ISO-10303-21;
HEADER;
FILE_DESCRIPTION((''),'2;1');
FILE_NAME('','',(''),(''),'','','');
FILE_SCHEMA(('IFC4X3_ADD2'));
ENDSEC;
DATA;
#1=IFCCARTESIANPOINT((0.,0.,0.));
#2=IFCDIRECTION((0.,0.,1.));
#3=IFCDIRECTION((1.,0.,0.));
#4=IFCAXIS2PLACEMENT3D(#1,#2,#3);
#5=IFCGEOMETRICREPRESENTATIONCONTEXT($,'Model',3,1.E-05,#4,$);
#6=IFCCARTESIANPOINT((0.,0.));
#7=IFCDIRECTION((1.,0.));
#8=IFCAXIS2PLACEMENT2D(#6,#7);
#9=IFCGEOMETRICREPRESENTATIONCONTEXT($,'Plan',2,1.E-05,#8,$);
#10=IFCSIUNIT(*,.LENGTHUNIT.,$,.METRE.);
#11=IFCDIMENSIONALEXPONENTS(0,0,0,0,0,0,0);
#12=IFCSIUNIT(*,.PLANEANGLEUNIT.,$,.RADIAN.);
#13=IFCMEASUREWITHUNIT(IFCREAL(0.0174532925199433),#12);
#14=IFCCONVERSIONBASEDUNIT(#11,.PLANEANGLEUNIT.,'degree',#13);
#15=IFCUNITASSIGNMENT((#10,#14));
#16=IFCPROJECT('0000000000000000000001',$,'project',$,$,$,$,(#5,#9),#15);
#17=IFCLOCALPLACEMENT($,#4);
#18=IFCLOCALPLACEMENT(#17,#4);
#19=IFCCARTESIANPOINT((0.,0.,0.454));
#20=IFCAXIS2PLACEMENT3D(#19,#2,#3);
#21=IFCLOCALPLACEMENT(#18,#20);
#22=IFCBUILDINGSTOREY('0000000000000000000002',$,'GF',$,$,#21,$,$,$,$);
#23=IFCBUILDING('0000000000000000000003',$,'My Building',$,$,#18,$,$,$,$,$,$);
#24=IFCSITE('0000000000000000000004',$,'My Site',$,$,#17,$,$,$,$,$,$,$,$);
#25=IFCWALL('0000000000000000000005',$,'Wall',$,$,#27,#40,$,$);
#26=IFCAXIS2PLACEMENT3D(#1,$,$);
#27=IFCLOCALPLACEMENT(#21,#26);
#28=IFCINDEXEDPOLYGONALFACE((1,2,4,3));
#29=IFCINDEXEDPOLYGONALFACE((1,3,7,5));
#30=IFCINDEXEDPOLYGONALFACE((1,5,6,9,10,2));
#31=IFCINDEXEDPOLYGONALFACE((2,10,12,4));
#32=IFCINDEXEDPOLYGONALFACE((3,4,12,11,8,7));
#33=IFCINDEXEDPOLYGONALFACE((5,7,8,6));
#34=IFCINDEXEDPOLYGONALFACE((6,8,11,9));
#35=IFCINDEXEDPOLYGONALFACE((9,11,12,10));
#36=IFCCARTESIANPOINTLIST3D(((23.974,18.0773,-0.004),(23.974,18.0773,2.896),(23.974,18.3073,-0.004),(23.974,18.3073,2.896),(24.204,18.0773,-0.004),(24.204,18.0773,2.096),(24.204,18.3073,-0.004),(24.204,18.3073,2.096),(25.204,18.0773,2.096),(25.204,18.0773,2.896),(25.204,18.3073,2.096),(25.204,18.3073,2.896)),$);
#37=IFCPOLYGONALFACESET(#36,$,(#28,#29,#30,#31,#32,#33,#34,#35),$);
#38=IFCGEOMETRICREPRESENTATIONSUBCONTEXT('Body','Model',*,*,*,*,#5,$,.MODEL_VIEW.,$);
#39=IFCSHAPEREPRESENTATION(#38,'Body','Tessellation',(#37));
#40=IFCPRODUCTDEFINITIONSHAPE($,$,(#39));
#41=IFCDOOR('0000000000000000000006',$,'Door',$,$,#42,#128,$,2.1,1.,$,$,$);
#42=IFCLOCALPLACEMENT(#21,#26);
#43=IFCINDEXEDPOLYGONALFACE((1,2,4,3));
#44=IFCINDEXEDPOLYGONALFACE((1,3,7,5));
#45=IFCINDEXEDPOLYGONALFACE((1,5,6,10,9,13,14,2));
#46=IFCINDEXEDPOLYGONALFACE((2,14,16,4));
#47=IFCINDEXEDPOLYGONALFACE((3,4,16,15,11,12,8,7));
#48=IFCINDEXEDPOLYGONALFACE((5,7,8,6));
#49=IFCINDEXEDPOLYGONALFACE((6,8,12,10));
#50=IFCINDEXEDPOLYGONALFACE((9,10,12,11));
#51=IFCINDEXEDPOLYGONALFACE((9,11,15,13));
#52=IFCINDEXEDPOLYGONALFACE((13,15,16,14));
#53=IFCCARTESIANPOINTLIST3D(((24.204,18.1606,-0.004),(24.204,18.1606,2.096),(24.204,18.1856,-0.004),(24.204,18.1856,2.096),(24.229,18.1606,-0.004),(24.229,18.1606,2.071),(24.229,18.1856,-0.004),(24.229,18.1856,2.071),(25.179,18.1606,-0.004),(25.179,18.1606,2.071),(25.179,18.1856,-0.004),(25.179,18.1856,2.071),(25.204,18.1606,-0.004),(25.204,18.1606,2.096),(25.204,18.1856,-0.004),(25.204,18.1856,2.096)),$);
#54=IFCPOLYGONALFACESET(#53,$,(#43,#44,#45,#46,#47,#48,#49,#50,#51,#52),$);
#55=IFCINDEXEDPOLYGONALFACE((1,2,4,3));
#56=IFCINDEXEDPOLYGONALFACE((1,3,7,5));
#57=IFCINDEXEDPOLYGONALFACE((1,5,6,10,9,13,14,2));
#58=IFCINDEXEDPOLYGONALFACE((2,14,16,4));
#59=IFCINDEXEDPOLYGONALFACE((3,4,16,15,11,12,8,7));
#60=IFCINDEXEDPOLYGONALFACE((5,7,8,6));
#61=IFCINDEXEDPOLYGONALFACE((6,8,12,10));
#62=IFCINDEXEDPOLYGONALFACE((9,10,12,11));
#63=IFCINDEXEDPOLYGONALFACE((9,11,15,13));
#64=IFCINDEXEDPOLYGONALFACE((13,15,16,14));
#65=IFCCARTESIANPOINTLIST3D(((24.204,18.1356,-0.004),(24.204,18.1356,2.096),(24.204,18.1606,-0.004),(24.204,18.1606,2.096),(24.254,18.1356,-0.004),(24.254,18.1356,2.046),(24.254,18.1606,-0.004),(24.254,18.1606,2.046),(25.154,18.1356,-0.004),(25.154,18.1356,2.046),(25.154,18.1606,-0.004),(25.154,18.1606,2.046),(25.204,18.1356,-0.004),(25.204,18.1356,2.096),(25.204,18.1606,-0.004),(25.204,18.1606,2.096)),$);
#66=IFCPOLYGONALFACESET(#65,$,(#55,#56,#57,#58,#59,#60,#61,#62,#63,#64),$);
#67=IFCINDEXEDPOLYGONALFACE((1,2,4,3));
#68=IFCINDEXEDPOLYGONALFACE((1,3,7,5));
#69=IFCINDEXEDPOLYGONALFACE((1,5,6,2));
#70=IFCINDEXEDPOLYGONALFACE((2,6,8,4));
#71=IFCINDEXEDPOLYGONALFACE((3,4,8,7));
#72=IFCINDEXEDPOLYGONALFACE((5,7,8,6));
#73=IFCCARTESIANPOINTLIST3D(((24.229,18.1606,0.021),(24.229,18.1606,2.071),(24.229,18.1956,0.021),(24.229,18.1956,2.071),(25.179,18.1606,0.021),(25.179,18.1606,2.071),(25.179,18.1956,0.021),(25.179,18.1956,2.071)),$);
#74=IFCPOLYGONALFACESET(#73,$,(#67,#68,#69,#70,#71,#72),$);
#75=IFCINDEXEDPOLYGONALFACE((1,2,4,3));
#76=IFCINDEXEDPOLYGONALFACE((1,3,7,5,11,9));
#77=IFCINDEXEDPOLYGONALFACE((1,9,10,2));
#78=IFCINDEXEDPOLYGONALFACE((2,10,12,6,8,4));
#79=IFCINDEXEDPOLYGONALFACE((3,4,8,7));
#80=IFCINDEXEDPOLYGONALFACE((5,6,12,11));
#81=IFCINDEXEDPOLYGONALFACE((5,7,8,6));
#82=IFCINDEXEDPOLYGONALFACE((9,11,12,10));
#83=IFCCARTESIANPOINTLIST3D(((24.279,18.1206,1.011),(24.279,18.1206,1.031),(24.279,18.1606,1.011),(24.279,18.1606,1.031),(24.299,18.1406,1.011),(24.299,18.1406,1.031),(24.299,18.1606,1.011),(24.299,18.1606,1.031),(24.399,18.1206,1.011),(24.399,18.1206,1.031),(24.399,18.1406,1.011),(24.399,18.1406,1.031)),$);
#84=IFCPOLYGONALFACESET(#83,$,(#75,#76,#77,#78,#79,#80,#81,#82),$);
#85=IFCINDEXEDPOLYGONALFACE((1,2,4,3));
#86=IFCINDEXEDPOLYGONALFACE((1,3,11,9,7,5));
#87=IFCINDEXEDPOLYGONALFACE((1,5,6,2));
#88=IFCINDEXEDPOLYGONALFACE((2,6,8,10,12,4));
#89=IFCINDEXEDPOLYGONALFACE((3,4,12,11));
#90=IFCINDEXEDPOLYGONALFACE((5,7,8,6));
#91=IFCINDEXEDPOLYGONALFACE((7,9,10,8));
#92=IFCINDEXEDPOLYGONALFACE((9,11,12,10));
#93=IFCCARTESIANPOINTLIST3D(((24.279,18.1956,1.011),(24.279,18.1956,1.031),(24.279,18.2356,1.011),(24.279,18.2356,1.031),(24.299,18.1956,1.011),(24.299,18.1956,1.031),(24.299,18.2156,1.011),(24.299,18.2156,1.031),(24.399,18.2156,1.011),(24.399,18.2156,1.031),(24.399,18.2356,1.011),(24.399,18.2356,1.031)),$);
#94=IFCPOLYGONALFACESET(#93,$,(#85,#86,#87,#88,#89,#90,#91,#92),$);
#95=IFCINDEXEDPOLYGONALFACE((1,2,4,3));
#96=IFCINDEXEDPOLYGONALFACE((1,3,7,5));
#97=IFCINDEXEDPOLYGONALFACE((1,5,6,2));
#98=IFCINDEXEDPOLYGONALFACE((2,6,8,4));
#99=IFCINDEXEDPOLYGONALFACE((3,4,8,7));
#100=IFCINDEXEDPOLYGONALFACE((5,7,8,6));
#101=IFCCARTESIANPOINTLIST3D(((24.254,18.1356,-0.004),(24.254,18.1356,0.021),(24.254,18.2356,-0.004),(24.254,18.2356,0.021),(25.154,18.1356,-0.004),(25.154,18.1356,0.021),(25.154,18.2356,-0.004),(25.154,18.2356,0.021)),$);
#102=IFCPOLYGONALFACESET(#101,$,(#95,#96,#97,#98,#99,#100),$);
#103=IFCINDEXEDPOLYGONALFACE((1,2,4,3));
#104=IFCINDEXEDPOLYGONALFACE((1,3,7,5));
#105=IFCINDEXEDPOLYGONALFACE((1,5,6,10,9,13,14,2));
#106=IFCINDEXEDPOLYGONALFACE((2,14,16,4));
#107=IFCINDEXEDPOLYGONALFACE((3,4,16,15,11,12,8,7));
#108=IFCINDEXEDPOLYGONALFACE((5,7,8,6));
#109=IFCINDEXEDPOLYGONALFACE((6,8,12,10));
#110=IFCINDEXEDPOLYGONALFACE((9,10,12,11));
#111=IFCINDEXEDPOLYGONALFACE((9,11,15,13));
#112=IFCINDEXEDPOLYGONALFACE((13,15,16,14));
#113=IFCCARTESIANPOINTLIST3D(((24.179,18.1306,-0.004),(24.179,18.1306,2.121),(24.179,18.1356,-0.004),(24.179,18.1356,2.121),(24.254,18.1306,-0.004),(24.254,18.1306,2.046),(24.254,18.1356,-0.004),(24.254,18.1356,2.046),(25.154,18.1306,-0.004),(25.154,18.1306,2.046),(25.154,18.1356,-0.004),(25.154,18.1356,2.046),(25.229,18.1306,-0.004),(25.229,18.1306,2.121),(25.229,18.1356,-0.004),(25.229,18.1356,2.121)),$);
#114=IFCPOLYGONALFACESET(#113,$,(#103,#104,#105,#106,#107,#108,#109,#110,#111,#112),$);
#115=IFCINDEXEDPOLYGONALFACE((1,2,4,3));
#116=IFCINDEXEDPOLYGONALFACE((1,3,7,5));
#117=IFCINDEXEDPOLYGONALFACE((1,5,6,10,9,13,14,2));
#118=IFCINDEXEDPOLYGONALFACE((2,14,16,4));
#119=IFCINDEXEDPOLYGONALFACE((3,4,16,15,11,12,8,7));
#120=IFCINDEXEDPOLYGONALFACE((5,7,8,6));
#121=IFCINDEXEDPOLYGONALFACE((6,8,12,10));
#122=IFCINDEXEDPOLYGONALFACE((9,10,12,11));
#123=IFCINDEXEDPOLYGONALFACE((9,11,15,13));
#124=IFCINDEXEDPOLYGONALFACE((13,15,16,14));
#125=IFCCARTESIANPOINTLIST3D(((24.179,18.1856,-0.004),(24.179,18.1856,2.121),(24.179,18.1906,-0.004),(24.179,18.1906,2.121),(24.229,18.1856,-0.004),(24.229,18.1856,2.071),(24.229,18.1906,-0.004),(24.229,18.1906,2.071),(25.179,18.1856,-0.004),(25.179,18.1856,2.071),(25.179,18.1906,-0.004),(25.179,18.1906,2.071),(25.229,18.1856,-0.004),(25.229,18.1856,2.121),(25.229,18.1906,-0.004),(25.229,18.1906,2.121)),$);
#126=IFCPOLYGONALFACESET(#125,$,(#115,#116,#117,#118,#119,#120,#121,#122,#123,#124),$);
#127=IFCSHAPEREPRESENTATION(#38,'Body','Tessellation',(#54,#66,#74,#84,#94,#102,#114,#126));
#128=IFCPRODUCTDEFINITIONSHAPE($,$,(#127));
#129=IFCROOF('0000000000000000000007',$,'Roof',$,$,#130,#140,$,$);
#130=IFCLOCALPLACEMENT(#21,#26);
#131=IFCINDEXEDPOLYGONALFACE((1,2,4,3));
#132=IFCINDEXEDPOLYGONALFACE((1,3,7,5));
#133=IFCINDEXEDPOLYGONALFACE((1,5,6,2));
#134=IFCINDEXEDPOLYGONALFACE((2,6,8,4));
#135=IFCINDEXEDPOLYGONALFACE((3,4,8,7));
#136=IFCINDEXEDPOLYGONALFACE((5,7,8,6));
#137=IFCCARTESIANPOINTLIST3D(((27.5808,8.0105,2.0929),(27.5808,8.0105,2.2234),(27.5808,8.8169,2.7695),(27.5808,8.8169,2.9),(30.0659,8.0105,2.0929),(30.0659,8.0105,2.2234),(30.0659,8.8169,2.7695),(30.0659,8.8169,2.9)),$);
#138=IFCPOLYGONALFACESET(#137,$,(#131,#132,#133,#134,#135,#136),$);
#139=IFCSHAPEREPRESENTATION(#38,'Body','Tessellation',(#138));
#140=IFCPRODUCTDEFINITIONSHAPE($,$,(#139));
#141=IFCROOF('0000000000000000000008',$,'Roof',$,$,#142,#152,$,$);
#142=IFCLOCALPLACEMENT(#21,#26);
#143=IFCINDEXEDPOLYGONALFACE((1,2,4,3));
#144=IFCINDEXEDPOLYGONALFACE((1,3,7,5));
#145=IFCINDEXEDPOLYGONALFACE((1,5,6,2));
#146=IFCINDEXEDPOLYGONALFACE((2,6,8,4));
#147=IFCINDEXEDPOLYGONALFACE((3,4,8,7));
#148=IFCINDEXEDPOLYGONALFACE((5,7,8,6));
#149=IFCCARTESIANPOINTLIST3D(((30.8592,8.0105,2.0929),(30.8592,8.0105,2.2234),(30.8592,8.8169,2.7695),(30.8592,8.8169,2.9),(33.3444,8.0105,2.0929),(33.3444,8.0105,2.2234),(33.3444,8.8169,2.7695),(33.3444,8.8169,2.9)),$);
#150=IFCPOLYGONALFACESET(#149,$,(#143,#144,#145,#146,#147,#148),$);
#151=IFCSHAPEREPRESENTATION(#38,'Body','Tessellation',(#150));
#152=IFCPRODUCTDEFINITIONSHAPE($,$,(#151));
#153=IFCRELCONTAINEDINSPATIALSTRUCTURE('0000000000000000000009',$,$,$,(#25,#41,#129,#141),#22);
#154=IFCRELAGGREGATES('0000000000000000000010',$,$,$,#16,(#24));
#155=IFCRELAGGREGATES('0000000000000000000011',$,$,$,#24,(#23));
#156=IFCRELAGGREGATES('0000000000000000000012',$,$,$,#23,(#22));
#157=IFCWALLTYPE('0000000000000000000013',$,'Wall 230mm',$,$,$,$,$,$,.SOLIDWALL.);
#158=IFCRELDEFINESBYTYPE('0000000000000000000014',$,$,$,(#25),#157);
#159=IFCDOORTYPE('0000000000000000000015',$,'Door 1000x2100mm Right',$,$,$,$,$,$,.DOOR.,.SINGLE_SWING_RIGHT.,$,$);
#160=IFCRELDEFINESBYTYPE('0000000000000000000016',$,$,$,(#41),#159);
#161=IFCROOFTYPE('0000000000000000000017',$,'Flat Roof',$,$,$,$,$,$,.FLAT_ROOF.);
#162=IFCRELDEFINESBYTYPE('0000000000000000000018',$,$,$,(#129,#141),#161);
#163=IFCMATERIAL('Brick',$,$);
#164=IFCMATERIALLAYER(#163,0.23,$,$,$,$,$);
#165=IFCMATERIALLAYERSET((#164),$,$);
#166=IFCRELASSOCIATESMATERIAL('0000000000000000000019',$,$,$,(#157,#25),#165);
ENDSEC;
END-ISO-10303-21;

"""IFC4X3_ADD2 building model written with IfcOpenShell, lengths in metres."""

from ifc_helpers import new_model, entity, si_unit, converted_unit, frame, origin_with_axes, origin_2d_with_axis, place, context, subcontext, project, spatial, polyline, line, indexed_curve, outline, extrude, shape, source, transform, mapped, material, layer, layer_set, layer_usage, type_object, type_shapes, element, fill, save


model = new_model("IFC4X3_ADD2")

# Units and contexts
model_context = context("Model", 3, precision=1e-05, world=origin_with_axes())
plan_context = context("Plan", 2, precision=1e-05, world=origin_2d_with_axis())
body_context_1 = subcontext(model_context, "Body", "Model", "MODEL_VIEW")
body_context_2 = subcontext(plan_context, "Body", "Plan", "PLAN_VIEW")
ifc_project = project(units=[si_unit("LENGTHUNIT", "METRE"), converted_unit("PLANEANGLEUNIT", "degree", entity("IfcReal", 0.0174532925199433), si_unit("PLANEANGLEUNIT", "RADIAN"), dimensions=[0, 0, 0, 0, 0, 0, 0])], contexts=[model_context, plan_context])

# Site, building, storey
site_placement = place(None, origin_with_axes())
site = spatial("IfcSite", under=ifc_project, at=site_placement, Name="My Site")
building_placement = place(site_placement, origin_with_axes())
building = spatial("IfcBuilding", under=site, at=building_placement, Name="My Building")
storey_placement = place(building_placement, frame((0.0, 0.0, 0.454), z_axis=(0.0, 0.0, 1.0), x_axis=(1.0, 0.0, 0.0)))
storey = spatial("IfcBuildingStorey", under=building, at=storey_placement, Name="GF")

# Shared definitions
ifc_material_1 = material(Name="Brick")

# Shared definitions
ifc_layer_1 = layer(ifc_material_1, 0.23)
ifc_layer_set_1 = layer_set([ifc_layer_1])
wall_type_1 = type_object("IfcWallType", Name="Wall 230mm", PredefinedType="SOLIDWALL", material=ifc_layer_set_1)

# Shared definitions
shared_shape_1 = source(origin_with_axes(), body_context_1, "Body", "SweptSolid", [
    extrude(outline(indexed_curve([(0.0, 0.0), (1.0, 0.0), (1.0, 2.1), (0.0, 2.1)], segments=[line(1, 2, 3, 4, 1)])), frame((0.0, -0.6, 0.0), z_axis=(0.0, -1.0, 0.0), x_axis=(1.0, 0.0, 0.0)), (0.0, 0.0, -1.0), 1.2),
])
door_type_1 = type_object("IfcDoorType", Name="Door 1000x2100mm Right", OperationType="SINGLE_SWING_RIGHT", PredefinedType="DOOR")
shared_shape_2 = source(origin_with_axes(), body_context_1, "Body", "SweptSolid", [
    extrude(outline(indexed_curve([(0.0, 0.0), (0.0, 2.1), (1.0, 2.1), (1.0, 0.0), (0.975, 0.0), (0.975, 2.075), (0.025, 2.075), (0.025, 0.0)], segments=[line(1, 2, 3, 4, 5, 6, 7, 8, 1)])), frame((0.0, 0.025, 0.0), z_axis=(0.0, -1.0, 0.0), x_axis=(1.0, 0.0, 0.0)), (0.0, 0.0, -1.0), 0.025),
    extrude(outline(indexed_curve([(0.0, 0.0), (0.0, 2.1), (1.0, 2.1), (1.0, 0.0), (0.95, 0.0), (0.95, 2.05), (0.05, 2.05), (0.05, 0.0)], segments=[line(1, 2, 3, 4, 5, 6, 7, 8, 1)])), frame((0.0, 0.0, 0.0), z_axis=(0.0, -1.0, 0.0), x_axis=(1.0, 0.0, 0.0)), (0.0, 0.0, -1.0), 0.025),
    extrude(outline(indexed_curve([(0.0, 0.0), (0.95, 0.0), (0.95, 0.035), (0.0, 0.035)], segments=[line(1, 2, 3, 4, 1)])), frame((0.025, 0.025, 0.025), z_axis=(0.0, 0.0, 1.0), x_axis=(1.0, 0.0, 0.0)), (0.0, 0.0, 1.0), 2.05),
    extrude(outline(indexed_curve([(0.0, 0.0), (0.0, -0.04), (0.12, -0.04), (0.12, -0.02), (0.02, -0.02), (0.02, 0.0)], segments=[line(1, 2, 3, 4, 5, 6, 1)])), frame((0.075, 0.025, 1.015), z_axis=(0.0, 0.0, 1.0), x_axis=(1.0, 0.0, 0.0)), (0.0, 0.0, 1.0), 0.02),
    extrude(outline(indexed_curve([(0.0, 0.0), (0.0, 0.04), (0.12, 0.04), (0.12, 0.02), (0.02, 0.02), (0.02, 0.0)], segments=[line(1, 2, 3, 4, 5, 6, 1)])), frame((0.075, 0.06, 1.015), z_axis=(0.0, 0.0, 1.0), x_axis=(1.0, 0.0, 0.0)), (0.0, 0.0, 1.0), 0.02),
    extrude(outline(indexed_curve([(0.0, 0.0), (0.9, 0.0), (0.9, 0.1), (0.0, 0.1)], segments=[line(1, 2, 3, 4, 1)])), frame((0.05, 0.0, 0.0), z_axis=(0.0, 0.0, 1.0), x_axis=(1.0, 0.0, 0.0)), (0.0, 0.0, 1.0), 0.025),
    extrude(outline(indexed_curve([(0.0, 0.0), (0.0, 2.125), (1.05, 2.125), (1.05, 0.0), (0.975, 0.0), (0.975, 2.05), (0.075, 2.05), (0.075, 0.0)], segments=[line(1, 2, 3, 4, 5, 6, 7, 8, 1)])), frame((-0.025, -0.005, 0.0), z_axis=(0.0, -1.0, 0.0), x_axis=(1.0, 0.0, 0.0)), (0.0, 0.0, -1.0), 0.005),
    extrude(outline(indexed_curve([(0.0, 0.0), (0.0, 2.125), (1.05, 2.125), (1.05, 0.0), (1.0, 0.0), (1.0, 2.075), (0.05, 2.075), (0.05, 0.0)], segments=[line(1, 2, 3, 4, 5, 6, 7, 8, 1)])), frame((-0.025, 0.05, 0.0), z_axis=(0.0, -1.0, 0.0), x_axis=(1.0, 0.0, 0.0)), (0.0, 0.0, -1.0), 0.005),
])
shared_shape_3 = source(origin_with_axes(), body_context_2, "Body", "Curve2D", [
    entity("IfcIndexedPolyCurve", entity("IfcCartesianPointList2D", [[0.0, 0.0], [0.0, 0.05], [0.025, 0.05], [0.025, 0.025], [0.05, 0.025], [0.05, 0.0]]), [entity("IfcLineIndex", [1, 2, 3, 4, 5, 6, 1])]),
    entity("IfcIndexedPolyCurve", entity("IfcCartesianPointList2D", [[1.0, 0.0], [1.0, 0.05], [0.975, 0.05], [0.975, 0.025], [0.95, 0.025], [0.95, 0.0]]), [entity("IfcLineIndex", [1, 2, 3, 4, 5, 6, 1])]),
    entity("IfcTrimmedCurve", entity("IfcEllipse", entity("IfcAxis2Placement2D", entity("IfcCartesianPoint", [0.94, 0.05]), entity("IfcDirection", [1.0, 0.0])), 0.915, 0.95), [entity("IfcCartesianPoint", [0.94, 1.0])], [entity("IfcCartesianPoint", [0.025, 0.05])], True, "CARTESIAN"),
    entity("IfcIndexedPolyCurve", entity("IfcCartesianPointList2D", [[0.975, 0.05], [0.94, 0.05], [0.94, 1.0], [0.975, 1.0]]), [entity("IfcLineIndex", [1, 2, 3, 4, 1])]),
])
type_shapes(door_type_1, [shared_shape_2, shared_shape_3])

# Wall, opening, door
ifc_layer_usage_1 = layer_usage(ifc_layer_set_1, "AXIS2", "POSITIVE", 0.0)
wall_1_placement = place(storey_placement, frame((25.204, 18.3073, -0.004), z_axis=(0.0, 0.0, 1.0), x_axis=(-1.0, 0.0, 0.0)))
wall_1 = element("IfcWall", 1, at=wall_1_placement, inside=storey, type_object=wall_type_1, material=ifc_layer_usage_1, Name="Wall", context=body_context_1, shape_type="SweptSolid", body=[
    extrude(outline(indexed_curve([(0.0, 0.0), (0.0, 0.23), (1.23, 0.23), (1.23, 0.0), (0.0, 0.0)], self_intersect=False)), origin_with_axes(), (0.0, 0.0, 1.0), 2.9),
])
opening_1_placement = place(wall_1_placement, frame((0.0, 0.0, 0.0), z_axis=(0.0, 0.0, 1.0), x_axis=(1.0, 0.0, 0.0)))
opening_1 = element("IfcOpeningElement", 2, at=opening_1_placement, cuts=wall_1, PredefinedType="OPENING", context=body_context_1, shape_type="MappedRepresentation", body=[
    mapped(shared_shape_1, transform((0.0, 0.0, 0.0), x_axis=(1.0, 0.0, 0.0), y_axis=(0.0, 1.0, 0.0), z_axis=(0.0, 0.0, 1.0), scale=1.0)),
])
door_1_placement = place(opening_1_placement, frame((1.0, 0.1717, 0.0), z_axis=(0.0, 0.0, 1.0), x_axis=(-1.0, 0.0, 0.0)))
door_1 = element("IfcDoor", 3, at=door_1_placement, inside=storey, type_object=door_type_1, Name="Door", OverallHeight=2.1, OverallWidth=1.0, shapes=[
    shape(body_context_1, "Body", "MappedRepresentation", [mapped(shared_shape_2, transform((0.0, 0.0, 0.0), x_axis=(1.0, 0.0, 0.0), y_axis=(0.0, 1.0, 0.0), z_axis=(0.0, 0.0, 1.0), scale=1.0))]),
    shape(body_context_2, "Body", "MappedRepresentation", [mapped(shared_shape_3, transform((0.0, 0.0, 0.0), x_axis=(1.0, 0.0, 0.0), y_axis=(0.0, 1.0, 0.0), z_axis=(0.0, 0.0, 1.0), scale=1.0))]),
])
fill(opening_1, door_1)

# Roofs
roof_type = type_object("IfcRoofType", Name="Flat Roof", PredefinedType="FLAT_ROOF")
for number, where, z_axis, x_axis, name in (
    (4, (27.5808, 8.0241, 2.1043), (0.0, -0.642788, 0.766044), (1.0, 0.0, 0.0), "Roof"),
    (5, (30.8592, 8.0241, 2.1043), (0.0, -0.642788, 0.766044), (1.0, 0.0, 0.0), "Roof"),
):
    element("IfcRoof", number, at=place(storey_placement, frame(where, z_axis=z_axis, x_axis=x_axis)), inside=storey, type_object=roof_type, Name=name, context=body_context_1, shape_type="SweptSolid", body=[
        extrude(outline(polyline([(-1.2426, -0.0653), (1.2426, -0.0653), (1.2426, 0.0653), (-1.2426, 0.0653), (-1.2426, -0.0653)])), frame((1.2426, 1.0768, 0.05), z_axis=(0.0, 0.766044, -0.642788), x_axis=(1.0, 0.0, 0.0)), (0.0, 0.642788, -0.766044), 1.0526),
    ])

save(model, "model.ifc")
